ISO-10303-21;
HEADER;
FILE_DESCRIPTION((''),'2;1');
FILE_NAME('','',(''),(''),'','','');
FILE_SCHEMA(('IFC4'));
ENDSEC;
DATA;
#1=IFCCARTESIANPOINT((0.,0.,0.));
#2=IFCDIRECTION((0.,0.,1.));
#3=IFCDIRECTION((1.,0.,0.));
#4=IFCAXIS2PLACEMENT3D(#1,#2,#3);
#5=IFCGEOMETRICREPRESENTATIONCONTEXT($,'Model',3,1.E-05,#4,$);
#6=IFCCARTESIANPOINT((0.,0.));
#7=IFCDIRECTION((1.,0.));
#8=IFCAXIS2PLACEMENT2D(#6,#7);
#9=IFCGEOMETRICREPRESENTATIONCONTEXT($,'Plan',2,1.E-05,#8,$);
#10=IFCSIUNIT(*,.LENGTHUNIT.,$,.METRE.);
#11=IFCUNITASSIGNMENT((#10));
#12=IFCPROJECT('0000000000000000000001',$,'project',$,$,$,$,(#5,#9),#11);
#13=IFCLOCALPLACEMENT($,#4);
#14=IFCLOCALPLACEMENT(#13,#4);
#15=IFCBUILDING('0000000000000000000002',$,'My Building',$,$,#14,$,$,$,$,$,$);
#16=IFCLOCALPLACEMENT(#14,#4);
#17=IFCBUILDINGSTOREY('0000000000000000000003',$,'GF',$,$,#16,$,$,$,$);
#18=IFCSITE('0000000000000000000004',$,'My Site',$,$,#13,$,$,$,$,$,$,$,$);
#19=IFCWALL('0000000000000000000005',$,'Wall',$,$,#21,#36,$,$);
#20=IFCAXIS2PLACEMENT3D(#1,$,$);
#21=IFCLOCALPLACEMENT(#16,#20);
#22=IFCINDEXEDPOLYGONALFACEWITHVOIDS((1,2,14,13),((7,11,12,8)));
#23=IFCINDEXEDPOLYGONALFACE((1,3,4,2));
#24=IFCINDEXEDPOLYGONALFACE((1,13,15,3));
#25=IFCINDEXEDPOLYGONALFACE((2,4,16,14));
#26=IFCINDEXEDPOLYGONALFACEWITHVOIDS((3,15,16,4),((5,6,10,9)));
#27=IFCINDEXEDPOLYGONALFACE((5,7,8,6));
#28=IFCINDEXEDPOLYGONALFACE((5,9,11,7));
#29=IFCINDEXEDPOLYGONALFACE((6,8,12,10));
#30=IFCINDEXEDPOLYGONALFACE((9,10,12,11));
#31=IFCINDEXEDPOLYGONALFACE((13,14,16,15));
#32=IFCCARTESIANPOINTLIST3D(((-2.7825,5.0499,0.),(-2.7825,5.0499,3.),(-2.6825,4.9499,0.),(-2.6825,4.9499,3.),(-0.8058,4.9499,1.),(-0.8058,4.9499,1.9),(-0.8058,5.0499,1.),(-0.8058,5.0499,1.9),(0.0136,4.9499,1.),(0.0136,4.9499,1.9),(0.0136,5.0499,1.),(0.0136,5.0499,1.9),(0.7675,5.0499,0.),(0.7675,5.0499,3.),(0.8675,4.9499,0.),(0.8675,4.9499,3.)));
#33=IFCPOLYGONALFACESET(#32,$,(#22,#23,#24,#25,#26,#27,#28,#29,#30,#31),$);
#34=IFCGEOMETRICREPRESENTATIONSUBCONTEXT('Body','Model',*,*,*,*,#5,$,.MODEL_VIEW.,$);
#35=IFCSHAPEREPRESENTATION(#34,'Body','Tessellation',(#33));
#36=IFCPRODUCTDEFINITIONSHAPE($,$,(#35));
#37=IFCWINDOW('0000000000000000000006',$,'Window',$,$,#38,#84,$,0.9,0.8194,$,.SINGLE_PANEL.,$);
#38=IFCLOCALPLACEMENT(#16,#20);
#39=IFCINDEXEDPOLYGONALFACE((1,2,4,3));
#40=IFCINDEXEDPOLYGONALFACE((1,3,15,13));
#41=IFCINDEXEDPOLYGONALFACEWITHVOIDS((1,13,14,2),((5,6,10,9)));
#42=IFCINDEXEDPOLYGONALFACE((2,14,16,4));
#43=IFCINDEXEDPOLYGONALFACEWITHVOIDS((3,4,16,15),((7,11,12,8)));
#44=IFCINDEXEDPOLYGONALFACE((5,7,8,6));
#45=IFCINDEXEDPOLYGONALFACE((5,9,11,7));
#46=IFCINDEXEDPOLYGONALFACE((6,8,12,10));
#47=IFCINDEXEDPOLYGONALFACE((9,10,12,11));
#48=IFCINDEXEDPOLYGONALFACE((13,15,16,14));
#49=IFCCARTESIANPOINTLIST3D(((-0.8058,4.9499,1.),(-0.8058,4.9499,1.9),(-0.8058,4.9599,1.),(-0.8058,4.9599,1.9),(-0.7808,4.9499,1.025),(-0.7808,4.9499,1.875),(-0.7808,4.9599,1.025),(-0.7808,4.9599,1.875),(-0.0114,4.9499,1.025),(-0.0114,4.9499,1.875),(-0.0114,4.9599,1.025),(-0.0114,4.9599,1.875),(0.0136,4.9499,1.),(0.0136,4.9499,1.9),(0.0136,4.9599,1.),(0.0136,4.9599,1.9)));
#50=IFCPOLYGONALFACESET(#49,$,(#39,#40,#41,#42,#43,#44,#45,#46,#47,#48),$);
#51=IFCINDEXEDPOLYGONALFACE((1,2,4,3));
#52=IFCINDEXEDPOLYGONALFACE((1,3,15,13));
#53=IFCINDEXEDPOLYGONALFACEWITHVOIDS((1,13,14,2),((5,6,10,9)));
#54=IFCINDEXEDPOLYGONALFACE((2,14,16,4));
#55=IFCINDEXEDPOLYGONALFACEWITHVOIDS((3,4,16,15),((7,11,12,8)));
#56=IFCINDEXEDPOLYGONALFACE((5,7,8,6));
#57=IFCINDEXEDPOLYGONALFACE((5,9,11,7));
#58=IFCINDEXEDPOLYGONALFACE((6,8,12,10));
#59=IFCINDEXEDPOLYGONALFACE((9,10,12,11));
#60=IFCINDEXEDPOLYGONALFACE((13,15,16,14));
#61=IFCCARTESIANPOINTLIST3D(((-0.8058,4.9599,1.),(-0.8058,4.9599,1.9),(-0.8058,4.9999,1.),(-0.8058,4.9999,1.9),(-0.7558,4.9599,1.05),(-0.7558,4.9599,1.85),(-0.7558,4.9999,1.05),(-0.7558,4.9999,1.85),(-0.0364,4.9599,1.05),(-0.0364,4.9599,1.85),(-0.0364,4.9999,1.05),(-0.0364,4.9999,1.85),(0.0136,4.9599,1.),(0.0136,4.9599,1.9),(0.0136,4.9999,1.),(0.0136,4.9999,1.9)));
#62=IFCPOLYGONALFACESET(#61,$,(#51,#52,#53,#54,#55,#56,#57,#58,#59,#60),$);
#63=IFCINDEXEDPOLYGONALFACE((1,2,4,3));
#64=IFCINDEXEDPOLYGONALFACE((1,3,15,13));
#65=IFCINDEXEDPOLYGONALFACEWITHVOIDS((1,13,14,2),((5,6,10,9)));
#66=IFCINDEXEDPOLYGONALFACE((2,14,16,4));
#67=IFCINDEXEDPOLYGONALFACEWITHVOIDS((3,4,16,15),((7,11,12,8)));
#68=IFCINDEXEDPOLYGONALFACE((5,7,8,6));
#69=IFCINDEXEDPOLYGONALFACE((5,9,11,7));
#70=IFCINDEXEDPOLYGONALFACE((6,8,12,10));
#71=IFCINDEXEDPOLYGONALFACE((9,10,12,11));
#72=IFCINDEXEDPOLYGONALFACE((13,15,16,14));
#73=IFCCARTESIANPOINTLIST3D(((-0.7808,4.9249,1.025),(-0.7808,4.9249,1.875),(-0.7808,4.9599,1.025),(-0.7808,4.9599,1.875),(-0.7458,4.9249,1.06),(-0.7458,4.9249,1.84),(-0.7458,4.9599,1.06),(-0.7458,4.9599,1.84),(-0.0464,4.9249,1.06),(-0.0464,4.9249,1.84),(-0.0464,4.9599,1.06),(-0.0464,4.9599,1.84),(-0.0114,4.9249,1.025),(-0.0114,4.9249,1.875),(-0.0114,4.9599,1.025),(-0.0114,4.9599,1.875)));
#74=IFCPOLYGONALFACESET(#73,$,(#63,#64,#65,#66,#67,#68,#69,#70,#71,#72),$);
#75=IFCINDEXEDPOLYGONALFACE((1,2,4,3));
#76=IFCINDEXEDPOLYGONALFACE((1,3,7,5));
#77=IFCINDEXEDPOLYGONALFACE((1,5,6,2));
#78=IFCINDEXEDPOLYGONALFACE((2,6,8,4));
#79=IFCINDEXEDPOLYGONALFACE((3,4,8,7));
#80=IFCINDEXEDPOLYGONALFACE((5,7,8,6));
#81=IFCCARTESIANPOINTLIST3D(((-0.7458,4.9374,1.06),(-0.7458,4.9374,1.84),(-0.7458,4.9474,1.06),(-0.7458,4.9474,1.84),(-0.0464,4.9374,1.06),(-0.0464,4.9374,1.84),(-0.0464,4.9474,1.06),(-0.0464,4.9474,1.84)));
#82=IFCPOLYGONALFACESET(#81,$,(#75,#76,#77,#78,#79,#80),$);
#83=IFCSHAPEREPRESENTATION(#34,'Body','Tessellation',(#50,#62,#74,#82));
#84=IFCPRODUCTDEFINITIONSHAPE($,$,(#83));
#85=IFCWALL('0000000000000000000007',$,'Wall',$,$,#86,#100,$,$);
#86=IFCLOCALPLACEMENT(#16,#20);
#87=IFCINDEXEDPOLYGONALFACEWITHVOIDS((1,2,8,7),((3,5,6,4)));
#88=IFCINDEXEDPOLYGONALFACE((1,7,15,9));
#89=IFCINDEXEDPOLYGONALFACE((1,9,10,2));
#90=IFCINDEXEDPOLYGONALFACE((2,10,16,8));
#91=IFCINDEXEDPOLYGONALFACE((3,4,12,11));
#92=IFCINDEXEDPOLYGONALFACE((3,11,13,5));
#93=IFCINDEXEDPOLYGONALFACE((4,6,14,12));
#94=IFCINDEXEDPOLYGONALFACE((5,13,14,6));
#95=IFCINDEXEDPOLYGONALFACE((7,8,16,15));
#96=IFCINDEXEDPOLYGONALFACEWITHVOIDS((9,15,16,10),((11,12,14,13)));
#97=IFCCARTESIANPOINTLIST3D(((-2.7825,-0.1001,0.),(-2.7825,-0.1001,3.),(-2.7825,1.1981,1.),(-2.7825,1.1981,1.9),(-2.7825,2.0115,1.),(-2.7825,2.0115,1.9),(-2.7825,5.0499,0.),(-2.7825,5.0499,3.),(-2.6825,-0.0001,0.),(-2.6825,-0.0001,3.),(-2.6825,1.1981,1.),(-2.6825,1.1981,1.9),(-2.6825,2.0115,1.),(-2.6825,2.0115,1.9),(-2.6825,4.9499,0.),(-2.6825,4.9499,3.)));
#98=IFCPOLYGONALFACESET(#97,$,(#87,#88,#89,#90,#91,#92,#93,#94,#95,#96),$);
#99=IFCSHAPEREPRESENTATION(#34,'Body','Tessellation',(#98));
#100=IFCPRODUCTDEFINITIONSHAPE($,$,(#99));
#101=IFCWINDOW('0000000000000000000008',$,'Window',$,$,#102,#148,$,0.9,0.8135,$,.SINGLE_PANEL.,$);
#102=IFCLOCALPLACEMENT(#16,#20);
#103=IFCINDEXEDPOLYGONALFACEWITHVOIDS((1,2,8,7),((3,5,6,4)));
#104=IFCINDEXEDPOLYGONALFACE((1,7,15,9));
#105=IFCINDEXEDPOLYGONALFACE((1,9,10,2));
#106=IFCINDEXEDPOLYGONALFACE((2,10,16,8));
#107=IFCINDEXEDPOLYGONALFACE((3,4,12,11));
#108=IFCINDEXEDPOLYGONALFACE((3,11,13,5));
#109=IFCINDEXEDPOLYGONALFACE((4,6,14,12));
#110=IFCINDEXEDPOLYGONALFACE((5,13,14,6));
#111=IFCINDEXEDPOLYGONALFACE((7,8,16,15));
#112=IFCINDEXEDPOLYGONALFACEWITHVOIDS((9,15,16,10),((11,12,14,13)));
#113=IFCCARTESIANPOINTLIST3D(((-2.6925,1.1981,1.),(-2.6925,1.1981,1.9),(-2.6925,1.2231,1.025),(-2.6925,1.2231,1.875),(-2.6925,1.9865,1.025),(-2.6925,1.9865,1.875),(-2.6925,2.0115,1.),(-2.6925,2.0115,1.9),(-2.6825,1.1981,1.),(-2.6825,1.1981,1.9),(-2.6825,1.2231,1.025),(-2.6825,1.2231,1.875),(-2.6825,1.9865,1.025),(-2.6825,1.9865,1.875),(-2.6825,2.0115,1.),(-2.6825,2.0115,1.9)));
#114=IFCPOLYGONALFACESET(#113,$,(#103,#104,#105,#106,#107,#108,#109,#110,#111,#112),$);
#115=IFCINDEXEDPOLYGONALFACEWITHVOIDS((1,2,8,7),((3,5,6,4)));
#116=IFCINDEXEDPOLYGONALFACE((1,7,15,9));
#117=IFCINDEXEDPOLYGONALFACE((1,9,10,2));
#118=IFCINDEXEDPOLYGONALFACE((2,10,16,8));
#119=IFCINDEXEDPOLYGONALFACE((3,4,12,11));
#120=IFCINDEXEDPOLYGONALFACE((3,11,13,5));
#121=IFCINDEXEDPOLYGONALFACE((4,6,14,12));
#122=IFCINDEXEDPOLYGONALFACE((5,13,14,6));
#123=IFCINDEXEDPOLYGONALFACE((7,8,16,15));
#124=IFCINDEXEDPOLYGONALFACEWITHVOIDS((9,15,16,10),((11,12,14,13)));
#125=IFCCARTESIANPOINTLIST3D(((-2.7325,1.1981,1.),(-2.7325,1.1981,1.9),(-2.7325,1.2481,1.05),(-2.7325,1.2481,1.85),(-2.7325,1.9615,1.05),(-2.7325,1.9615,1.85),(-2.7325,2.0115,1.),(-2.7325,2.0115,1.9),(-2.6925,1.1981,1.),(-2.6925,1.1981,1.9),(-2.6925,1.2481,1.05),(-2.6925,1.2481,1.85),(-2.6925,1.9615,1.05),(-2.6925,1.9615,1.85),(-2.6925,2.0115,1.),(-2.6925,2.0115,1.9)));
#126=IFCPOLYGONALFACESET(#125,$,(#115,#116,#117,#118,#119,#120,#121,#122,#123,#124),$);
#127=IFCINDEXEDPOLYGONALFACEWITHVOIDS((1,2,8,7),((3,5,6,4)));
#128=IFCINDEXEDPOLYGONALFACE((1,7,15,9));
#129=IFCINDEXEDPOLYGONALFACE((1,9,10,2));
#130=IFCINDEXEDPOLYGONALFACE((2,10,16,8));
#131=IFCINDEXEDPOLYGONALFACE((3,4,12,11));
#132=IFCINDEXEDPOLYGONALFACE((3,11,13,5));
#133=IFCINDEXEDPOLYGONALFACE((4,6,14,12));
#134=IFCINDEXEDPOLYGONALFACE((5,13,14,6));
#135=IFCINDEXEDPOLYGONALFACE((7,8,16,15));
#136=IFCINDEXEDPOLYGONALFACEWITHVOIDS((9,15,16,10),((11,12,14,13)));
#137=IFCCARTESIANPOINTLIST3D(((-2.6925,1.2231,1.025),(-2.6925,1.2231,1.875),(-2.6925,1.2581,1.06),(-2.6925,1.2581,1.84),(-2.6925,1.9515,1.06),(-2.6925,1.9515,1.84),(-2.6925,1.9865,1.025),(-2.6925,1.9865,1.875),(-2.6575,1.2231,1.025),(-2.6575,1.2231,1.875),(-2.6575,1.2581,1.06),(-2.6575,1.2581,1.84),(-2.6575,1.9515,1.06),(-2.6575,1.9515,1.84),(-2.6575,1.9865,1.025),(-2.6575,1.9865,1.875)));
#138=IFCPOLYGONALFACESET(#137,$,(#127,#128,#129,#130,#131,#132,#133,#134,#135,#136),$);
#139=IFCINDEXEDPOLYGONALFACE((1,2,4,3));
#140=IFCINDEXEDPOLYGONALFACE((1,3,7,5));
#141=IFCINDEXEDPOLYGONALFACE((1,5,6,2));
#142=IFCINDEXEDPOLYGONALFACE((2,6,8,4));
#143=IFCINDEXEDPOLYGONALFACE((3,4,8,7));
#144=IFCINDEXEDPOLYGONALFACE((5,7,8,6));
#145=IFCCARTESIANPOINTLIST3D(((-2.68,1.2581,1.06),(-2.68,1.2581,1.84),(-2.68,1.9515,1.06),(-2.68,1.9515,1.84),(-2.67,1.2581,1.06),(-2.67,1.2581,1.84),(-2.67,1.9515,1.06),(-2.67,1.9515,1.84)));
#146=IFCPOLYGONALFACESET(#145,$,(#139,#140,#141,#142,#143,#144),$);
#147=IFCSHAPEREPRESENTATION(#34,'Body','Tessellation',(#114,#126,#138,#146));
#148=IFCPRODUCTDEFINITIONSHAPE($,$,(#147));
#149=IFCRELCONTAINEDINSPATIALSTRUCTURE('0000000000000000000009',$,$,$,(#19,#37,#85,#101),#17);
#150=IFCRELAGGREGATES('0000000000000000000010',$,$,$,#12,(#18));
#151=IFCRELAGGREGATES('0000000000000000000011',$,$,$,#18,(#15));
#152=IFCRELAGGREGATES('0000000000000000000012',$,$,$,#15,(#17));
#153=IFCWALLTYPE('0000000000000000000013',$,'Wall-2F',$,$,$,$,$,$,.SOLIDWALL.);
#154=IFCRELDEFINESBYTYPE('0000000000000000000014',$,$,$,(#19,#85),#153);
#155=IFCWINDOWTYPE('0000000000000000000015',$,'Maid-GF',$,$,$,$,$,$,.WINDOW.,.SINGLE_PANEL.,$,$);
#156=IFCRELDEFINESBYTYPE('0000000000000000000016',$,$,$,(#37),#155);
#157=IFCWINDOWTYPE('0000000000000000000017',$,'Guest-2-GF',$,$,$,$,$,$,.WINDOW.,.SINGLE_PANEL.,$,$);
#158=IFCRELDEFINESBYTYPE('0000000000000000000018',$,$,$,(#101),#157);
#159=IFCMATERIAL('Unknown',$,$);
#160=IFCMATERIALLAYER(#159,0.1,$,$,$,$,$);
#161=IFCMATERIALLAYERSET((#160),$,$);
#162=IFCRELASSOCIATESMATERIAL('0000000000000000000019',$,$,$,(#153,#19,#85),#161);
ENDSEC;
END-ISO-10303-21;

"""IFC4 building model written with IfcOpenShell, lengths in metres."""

from ifc_helpers import new_model, entity, si_unit, frame, origin_with_axes, origin_2d_with_axis, place, context, subcontext, project, spatial, line, indexed_curve, outline, extrude, shape, source, transform, mapped, material, layer, layer_set, layer_usage, type_object, type_shapes, element, fill, save


model = new_model("IFC4")

# Units and contexts
model_context = context("Model", 3, precision=1e-05, world=origin_with_axes())
plan_context = context("Plan", 2, precision=1e-05, world=origin_2d_with_axis())
body_context_1 = subcontext(model_context, "Body", "Model", "MODEL_VIEW")
body_context_2 = subcontext(plan_context, "Body", "Plan", "PLAN_VIEW")
ifc_project = project(units=[si_unit("LENGTHUNIT", "METRE")], contexts=[model_context, plan_context])

# Site, building, storey
site_placement = place(None, origin_with_axes())
site = spatial("IfcSite", under=ifc_project, at=site_placement, Name="My Site")
building_placement = place(site_placement, origin_with_axes())
building = spatial("IfcBuilding", under=site, at=building_placement, Name="My Building")
storey_placement = place(building_placement, origin_with_axes())
storey = spatial("IfcBuildingStorey", under=building, at=storey_placement, Name="GF")

# Shared definitions
ifc_material_1 = material(Name="Unknown")

# Shared definitions
ifc_layer_1 = layer(ifc_material_1, 0.1)
ifc_layer_set_1 = layer_set([ifc_layer_1])
wall_type = type_object("IfcWallType", Name="Wall-2F", PredefinedType="SOLIDWALL", material=ifc_layer_set_1)

# Walls, openings, windows
ifc_layer_usage_1 = layer_usage(ifc_layer_set_1, "AXIS2", "POSITIVE", 0.0)
wall_1_placement = place(storey_placement, frame((0.7675, 5.0499, 0.0), z_axis=(0.0, 0.0, 1.0), x_axis=(-1.0, 0.0, 0.0)))
wall_1 = element("IfcWall", 1, at=wall_1_placement, inside=storey, type_object=wall_type, material=ifc_layer_usage_1, Name="Wall", context=body_context_1, shape_type="SweptSolid", body=[
    extrude(outline(indexed_curve([(0.0, 0.0), (-0.1, 0.1), (3.45, 0.1), (3.55, 0.0)], segments=[line(1, 2, 3, 4, 1)])), origin_with_axes(), (0.0, 0.0, 1.0), 3.0),
])
shared_shape_1 = source(origin_with_axes(), body_context_1, "Body", "SweptSolid", [
    extrude(outline(indexed_curve([(0.0, 0.0), (0.8194, 0.0), (0.8194, 0.9), (0.0, 0.9)], segments=[line(1, 2, 3, 4, 1)])), frame((0.0, -0.6, 0.0), z_axis=(0.0, -1.0, 0.0), x_axis=(1.0, 0.0, 0.0)), (0.0, 0.0, -1.0), 1.2),
])
opening_1_placement = place(wall_1_placement, frame((0.7539, 0.0, 1.0), z_axis=(0.0, 0.0, 1.0), x_axis=(1.0, 0.0, 0.0)))
opening_1 = element("IfcOpeningElement", 2, at=opening_1_placement, cuts=wall_1, PredefinedType="OPENING", context=body_context_1, shape_type="MappedRepresentation", body=[
    mapped(shared_shape_1, transform((0.0, 0.0, 0.0), x_axis=(1.0, 0.0, 0.0), y_axis=(0.0, 1.0, 0.0), z_axis=(0.0, 0.0, 1.0), scale=1.0)),
])
window_type_1 = type_object("IfcWindowType", Name="Maid-GF", PartitioningType="SINGLE_PANEL", PredefinedType="WINDOW")
shared_shape_2 = source(origin_with_axes(), body_context_1, "Body", "SweptSolid", [
    extrude(outline(indexed_curve([(0.0, 0.0), (0.8194, 0.0), (0.8194, 0.9), (0.0, 0.9)], segments=[line(1, 2, 3, 4, 1)]), holes=[indexed_curve([(0.025, 0.025), (0.7944, 0.025), (0.7944, 0.875), (0.025, 0.875)], segments=[line(1, 2, 3, 4, 1)])]), frame((0.0, 0.09, 0.0), z_axis=(0.0, -1.0, 0.0), x_axis=(1.0, 0.0, 0.0)), (0.0, 0.0, -1.0), 0.01),
    extrude(outline(indexed_curve([(0.0, 0.0), (0.8194, 0.0), (0.8194, 0.9), (0.0, 0.9)], segments=[line(1, 2, 3, 4, 1)]), holes=[indexed_curve([(0.05, 0.05), (0.7694, 0.05), (0.7694, 0.85), (0.05, 0.85)], segments=[line(1, 2, 3, 4, 1)])]), frame((0.0, 0.05, 0.0), z_axis=(0.0, -1.0, 0.0), x_axis=(1.0, 0.0, 0.0)), (0.0, 0.0, -1.0), 0.04),
    extrude(outline(indexed_curve([(0.0, 0.0), (0.7694, 0.0), (0.7694, 0.85), (0.0, 0.85)], segments=[line(1, 2, 3, 4, 1)]), holes=[indexed_curve([(0.035, 0.035), (0.7344, 0.035), (0.7344, 0.815), (0.035, 0.815)], segments=[line(1, 2, 3, 4, 1)])]), frame((0.025, 0.09, 0.025), z_axis=(0.0, -1.0, 0.0), x_axis=(1.0, 0.0, 0.0)), (0.0, 0.0, -1.0), 0.035),
    extrude(outline(indexed_curve([(0.035, 0.035), (0.7344, 0.035), (0.7344, 0.815), (0.035, 0.815)], segments=[line(1, 2, 3, 4, 1)])), frame((0.025, 0.1025, 0.025), z_axis=(0.0, -1.0, 0.0), x_axis=(1.0, 0.0, 0.0)), (0.0, 0.0, -1.0), 0.01),
])
shared_shape_3 = source(origin_with_axes(), body_context_2, "Body", "Curve2D", [
    entity("IfcIndexedPolyCurve", entity("IfcCartesianPointList2D", [[0.05, 0.05], [0.7694, 0.05]])),
    entity("IfcIndexedPolyCurve", entity("IfcCartesianPointList2D", [[0.0, 0.1], [0.025, 0.1], [0.025, 0.09], [0.05, 0.09], [0.05, 0.05], [0.0, 0.05]]), [entity("IfcLineIndex", [1, 2, 3, 4, 5, 6, 1])]),
    entity("IfcIndexedPolyCurve", entity("IfcCartesianPointList2D", [[0.8194, 0.1], [0.7944, 0.1], [0.7944, 0.09], [0.7694, 0.09], [0.7694, 0.05], [0.8194, 0.05]]), [entity("IfcLineIndex", [1, 2, 3, 4, 5, 6, 1])]),
    entity("IfcIndexedPolyCurve", entity("IfcCartesianPointList2D", [[0.025, 0.09], [0.06, 0.09], [0.06, 0.125], [0.025, 0.125]]), [entity("IfcLineIndex", [1, 2, 3, 4, 1])]),
    entity("IfcIndexedPolyCurve", entity("IfcCartesianPointList2D", [[0.7944, 0.09], [0.7594, 0.09], [0.7594, 0.125], [0.7944, 0.125]]), [entity("IfcLineIndex", [1, 2, 3, 4, 1])]),
    entity("IfcIndexedPolyCurve", entity("IfcCartesianPointList2D", [[0.06, 0.09], [0.7594, 0.09]])),
    entity("IfcIndexedPolyCurve", entity("IfcCartesianPointList2D", [[0.06, 0.125], [0.7594, 0.125]])),
    entity("IfcIndexedPolyCurve", entity("IfcCartesianPointList2D", [[0.06, 0.1075], [0.7594, 0.1075]])),
])
type_shapes(window_type_1, [shared_shape_2, shared_shape_3])
window_1_placement = place(opening_1_placement, frame((0.0, 0.0, 0.0), z_axis=(0.0, 0.0, 1.0), x_axis=(1.0, 0.0, 0.0)))
window_1 = element("IfcWindow", 3, at=window_1_placement, inside=storey, type_object=window_type_1, Name="Window", OverallHeight=0.9, OverallWidth=0.8194, PartitioningType="SINGLE_PANEL", shapes=[
    shape(body_context_1, "Body", "MappedRepresentation", [mapped(shared_shape_2, transform((0.0, 0.0, 0.0), x_axis=(1.0, 0.0, 0.0), y_axis=(0.0, 1.0, 0.0), z_axis=(0.0, 0.0, 1.0), scale=1.0))]),
    shape(body_context_2, "Body", "MappedRepresentation", [mapped(shared_shape_3, transform((0.0, 0.0, 0.0), x_axis=(1.0, 0.0, 0.0), y_axis=(0.0, 1.0, 0.0), z_axis=(0.0, 0.0, 1.0), scale=1.0))]),
])
fill(opening_1, window_1)
ifc_layer_usage_2 = layer_usage(ifc_layer_set_1, "AXIS2", "POSITIVE", 0.0)
wall_2_placement = place(storey_placement, frame((-2.7825, 5.0499, 0.0), z_axis=(0.0, 0.0, 1.0), x_axis=(0.0, -1.0, 0.0)))
wall_2 = element("IfcWall", 4, at=wall_2_placement, inside=storey, type_object=wall_type, material=ifc_layer_usage_2, Name="Wall", context=body_context_1, shape_type="SweptSolid", body=[
    extrude(outline(indexed_curve([(0.0, 0.0), (0.1, 0.1), (5.05, 0.1), (5.15, 0.0)], segments=[line(1, 2, 3, 4, 1)])), origin_with_axes(), (0.0, 0.0, 1.0), 3.0),
])
shared_shape_4 = source(origin_with_axes(), body_context_1, "Body", "SweptSolid", [
    extrude(outline(indexed_curve([(0.0, 0.0), (0.8135, 0.0), (0.8135, 0.9), (0.0, 0.9)], segments=[line(1, 2, 3, 4, 1)])), frame((0.0, -0.6, 0.0), z_axis=(0.0, -1.0, 0.0), x_axis=(1.0, 0.0, 0.0)), (0.0, 0.0, -1.0), 1.2),
])
opening_2_placement = place(wall_2_placement, frame((3.0384, 0.0, 1.0), z_axis=(0.0, 0.0, 1.0), x_axis=(1.0, 0.0, 0.0)))
opening_2 = element("IfcOpeningElement", 5, at=opening_2_placement, cuts=wall_2, PredefinedType="OPENING", context=body_context_1, shape_type="MappedRepresentation", body=[
    mapped(shared_shape_4, transform((0.0, 0.0, 0.0), x_axis=(1.0, 0.0, 0.0), y_axis=(0.0, 1.0, 0.0), z_axis=(0.0, 0.0, 1.0), scale=1.0)),
])
window_type_2 = type_object("IfcWindowType", Name="Guest-2-GF", PartitioningType="SINGLE_PANEL", PredefinedType="WINDOW")
shared_shape_5 = source(origin_with_axes(), body_context_1, "Body", "SweptSolid", [
    extrude(outline(indexed_curve([(0.0, 0.0), (0.8135, 0.0), (0.8135, 0.9), (0.0, 0.9)], segments=[line(1, 2, 3, 4, 1)]), holes=[indexed_curve([(0.025, 0.025), (0.7885, 0.025), (0.7885, 0.875), (0.025, 0.875)], segments=[line(1, 2, 3, 4, 1)])]), frame((0.0, 0.09, 0.0), z_axis=(0.0, -1.0, 0.0), x_axis=(1.0, 0.0, 0.0)), (0.0, 0.0, -1.0), 0.01),
    extrude(outline(indexed_curve([(0.0, 0.0), (0.8135, 0.0), (0.8135, 0.9), (0.0, 0.9)], segments=[line(1, 2, 3, 4, 1)]), holes=[indexed_curve([(0.05, 0.05), (0.7635, 0.05), (0.7635, 0.85), (0.05, 0.85)], segments=[line(1, 2, 3, 4, 1)])]), frame((0.0, 0.05, 0.0), z_axis=(0.0, -1.0, 0.0), x_axis=(1.0, 0.0, 0.0)), (0.0, 0.0, -1.0), 0.04),
    extrude(outline(indexed_curve([(0.0, 0.0), (0.7635, 0.0), (0.7635, 0.85), (0.0, 0.85)], segments=[line(1, 2, 3, 4, 1)]), holes=[indexed_curve([(0.035, 0.035), (0.7285, 0.035), (0.7285, 0.815), (0.035, 0.815)], segments=[line(1, 2, 3, 4, 1)])]), frame((0.025, 0.09, 0.025), z_axis=(0.0, -1.0, 0.0), x_axis=(1.0, 0.0, 0.0)), (0.0, 0.0, -1.0), 0.035),
    extrude(outline(indexed_curve([(0.035, 0.035), (0.7285, 0.035), (0.7285, 0.815), (0.035, 0.815)], segments=[line(1, 2, 3, 4, 1)])), frame((0.025, 0.1025, 0.025), z_axis=(0.0, -1.0, 0.0), x_axis=(1.0, 0.0, 0.0)), (0.0, 0.0, -1.0), 0.01),
])
shared_shape_6 = source(origin_with_axes(), body_context_2, "Body", "Curve2D", [
    entity("IfcIndexedPolyCurve", entity("IfcCartesianPointList2D", [[0.05, 0.05], [0.7635, 0.05]])),
    entity("IfcIndexedPolyCurve", entity("IfcCartesianPointList2D", [[0.0, 0.1], [0.025, 0.1], [0.025, 0.09], [0.05, 0.09], [0.05, 0.05], [0.0, 0.05]]), [entity("IfcLineIndex", [1, 2, 3, 4, 5, 6, 1])]),
    entity("IfcIndexedPolyCurve", entity("IfcCartesianPointList2D", [[0.8135, 0.1], [0.7885, 0.1], [0.7885, 0.09], [0.7635, 0.09], [0.7635, 0.05], [0.8135, 0.05]]), [entity("IfcLineIndex", [1, 2, 3, 4, 5, 6, 1])]),
    entity("IfcIndexedPolyCurve", entity("IfcCartesianPointList2D", [[0.025, 0.09], [0.06, 0.09], [0.06, 0.125], [0.025, 0.125]]), [entity("IfcLineIndex", [1, 2, 3, 4, 1])]),
    entity("IfcIndexedPolyCurve", entity("IfcCartesianPointList2D", [[0.7885, 0.09], [0.7535, 0.09], [0.7535, 0.125], [0.7885, 0.125]]), [entity("IfcLineIndex", [1, 2, 3, 4, 1])]),
    entity("IfcIndexedPolyCurve", entity("IfcCartesianPointList2D", [[0.06, 0.09], [0.7535, 0.09]])),
    entity("IfcIndexedPolyCurve", entity("IfcCartesianPointList2D", [[0.06, 0.125], [0.7535, 0.125]])),
    entity("IfcIndexedPolyCurve", entity("IfcCartesianPointList2D", [[0.06, 0.1075], [0.7535, 0.1075]])),
])
type_shapes(window_type_2, [shared_shape_5, shared_shape_6])
window_2_placement = place(opening_2_placement, frame((0.0, 0.0, 0.0), z_axis=(0.0, 0.0, 1.0), x_axis=(1.0, 0.0, 0.0)))
window_2 = element("IfcWindow", 6, at=window_2_placement, inside=storey, type_object=window_type_2, Name="Window", OverallHeight=0.9, OverallWidth=0.8135, PartitioningType="SINGLE_PANEL", shapes=[
    shape(body_context_1, "Body", "MappedRepresentation", [mapped(shared_shape_5, transform((0.0, 0.0, 0.0), x_axis=(1.0, 0.0, 0.0), y_axis=(0.0, 1.0, 0.0), z_axis=(0.0, 0.0, 1.0), scale=1.0))]),
    shape(body_context_2, "Body", "MappedRepresentation", [mapped(shared_shape_6, transform((0.0, 0.0, 0.0), x_axis=(1.0, 0.0, 0.0), y_axis=(0.0, 1.0, 0.0), z_axis=(0.0, 0.0, 1.0), scale=1.0))]),
])
fill(opening_2, window_2)

save(model, "model.ifc")
